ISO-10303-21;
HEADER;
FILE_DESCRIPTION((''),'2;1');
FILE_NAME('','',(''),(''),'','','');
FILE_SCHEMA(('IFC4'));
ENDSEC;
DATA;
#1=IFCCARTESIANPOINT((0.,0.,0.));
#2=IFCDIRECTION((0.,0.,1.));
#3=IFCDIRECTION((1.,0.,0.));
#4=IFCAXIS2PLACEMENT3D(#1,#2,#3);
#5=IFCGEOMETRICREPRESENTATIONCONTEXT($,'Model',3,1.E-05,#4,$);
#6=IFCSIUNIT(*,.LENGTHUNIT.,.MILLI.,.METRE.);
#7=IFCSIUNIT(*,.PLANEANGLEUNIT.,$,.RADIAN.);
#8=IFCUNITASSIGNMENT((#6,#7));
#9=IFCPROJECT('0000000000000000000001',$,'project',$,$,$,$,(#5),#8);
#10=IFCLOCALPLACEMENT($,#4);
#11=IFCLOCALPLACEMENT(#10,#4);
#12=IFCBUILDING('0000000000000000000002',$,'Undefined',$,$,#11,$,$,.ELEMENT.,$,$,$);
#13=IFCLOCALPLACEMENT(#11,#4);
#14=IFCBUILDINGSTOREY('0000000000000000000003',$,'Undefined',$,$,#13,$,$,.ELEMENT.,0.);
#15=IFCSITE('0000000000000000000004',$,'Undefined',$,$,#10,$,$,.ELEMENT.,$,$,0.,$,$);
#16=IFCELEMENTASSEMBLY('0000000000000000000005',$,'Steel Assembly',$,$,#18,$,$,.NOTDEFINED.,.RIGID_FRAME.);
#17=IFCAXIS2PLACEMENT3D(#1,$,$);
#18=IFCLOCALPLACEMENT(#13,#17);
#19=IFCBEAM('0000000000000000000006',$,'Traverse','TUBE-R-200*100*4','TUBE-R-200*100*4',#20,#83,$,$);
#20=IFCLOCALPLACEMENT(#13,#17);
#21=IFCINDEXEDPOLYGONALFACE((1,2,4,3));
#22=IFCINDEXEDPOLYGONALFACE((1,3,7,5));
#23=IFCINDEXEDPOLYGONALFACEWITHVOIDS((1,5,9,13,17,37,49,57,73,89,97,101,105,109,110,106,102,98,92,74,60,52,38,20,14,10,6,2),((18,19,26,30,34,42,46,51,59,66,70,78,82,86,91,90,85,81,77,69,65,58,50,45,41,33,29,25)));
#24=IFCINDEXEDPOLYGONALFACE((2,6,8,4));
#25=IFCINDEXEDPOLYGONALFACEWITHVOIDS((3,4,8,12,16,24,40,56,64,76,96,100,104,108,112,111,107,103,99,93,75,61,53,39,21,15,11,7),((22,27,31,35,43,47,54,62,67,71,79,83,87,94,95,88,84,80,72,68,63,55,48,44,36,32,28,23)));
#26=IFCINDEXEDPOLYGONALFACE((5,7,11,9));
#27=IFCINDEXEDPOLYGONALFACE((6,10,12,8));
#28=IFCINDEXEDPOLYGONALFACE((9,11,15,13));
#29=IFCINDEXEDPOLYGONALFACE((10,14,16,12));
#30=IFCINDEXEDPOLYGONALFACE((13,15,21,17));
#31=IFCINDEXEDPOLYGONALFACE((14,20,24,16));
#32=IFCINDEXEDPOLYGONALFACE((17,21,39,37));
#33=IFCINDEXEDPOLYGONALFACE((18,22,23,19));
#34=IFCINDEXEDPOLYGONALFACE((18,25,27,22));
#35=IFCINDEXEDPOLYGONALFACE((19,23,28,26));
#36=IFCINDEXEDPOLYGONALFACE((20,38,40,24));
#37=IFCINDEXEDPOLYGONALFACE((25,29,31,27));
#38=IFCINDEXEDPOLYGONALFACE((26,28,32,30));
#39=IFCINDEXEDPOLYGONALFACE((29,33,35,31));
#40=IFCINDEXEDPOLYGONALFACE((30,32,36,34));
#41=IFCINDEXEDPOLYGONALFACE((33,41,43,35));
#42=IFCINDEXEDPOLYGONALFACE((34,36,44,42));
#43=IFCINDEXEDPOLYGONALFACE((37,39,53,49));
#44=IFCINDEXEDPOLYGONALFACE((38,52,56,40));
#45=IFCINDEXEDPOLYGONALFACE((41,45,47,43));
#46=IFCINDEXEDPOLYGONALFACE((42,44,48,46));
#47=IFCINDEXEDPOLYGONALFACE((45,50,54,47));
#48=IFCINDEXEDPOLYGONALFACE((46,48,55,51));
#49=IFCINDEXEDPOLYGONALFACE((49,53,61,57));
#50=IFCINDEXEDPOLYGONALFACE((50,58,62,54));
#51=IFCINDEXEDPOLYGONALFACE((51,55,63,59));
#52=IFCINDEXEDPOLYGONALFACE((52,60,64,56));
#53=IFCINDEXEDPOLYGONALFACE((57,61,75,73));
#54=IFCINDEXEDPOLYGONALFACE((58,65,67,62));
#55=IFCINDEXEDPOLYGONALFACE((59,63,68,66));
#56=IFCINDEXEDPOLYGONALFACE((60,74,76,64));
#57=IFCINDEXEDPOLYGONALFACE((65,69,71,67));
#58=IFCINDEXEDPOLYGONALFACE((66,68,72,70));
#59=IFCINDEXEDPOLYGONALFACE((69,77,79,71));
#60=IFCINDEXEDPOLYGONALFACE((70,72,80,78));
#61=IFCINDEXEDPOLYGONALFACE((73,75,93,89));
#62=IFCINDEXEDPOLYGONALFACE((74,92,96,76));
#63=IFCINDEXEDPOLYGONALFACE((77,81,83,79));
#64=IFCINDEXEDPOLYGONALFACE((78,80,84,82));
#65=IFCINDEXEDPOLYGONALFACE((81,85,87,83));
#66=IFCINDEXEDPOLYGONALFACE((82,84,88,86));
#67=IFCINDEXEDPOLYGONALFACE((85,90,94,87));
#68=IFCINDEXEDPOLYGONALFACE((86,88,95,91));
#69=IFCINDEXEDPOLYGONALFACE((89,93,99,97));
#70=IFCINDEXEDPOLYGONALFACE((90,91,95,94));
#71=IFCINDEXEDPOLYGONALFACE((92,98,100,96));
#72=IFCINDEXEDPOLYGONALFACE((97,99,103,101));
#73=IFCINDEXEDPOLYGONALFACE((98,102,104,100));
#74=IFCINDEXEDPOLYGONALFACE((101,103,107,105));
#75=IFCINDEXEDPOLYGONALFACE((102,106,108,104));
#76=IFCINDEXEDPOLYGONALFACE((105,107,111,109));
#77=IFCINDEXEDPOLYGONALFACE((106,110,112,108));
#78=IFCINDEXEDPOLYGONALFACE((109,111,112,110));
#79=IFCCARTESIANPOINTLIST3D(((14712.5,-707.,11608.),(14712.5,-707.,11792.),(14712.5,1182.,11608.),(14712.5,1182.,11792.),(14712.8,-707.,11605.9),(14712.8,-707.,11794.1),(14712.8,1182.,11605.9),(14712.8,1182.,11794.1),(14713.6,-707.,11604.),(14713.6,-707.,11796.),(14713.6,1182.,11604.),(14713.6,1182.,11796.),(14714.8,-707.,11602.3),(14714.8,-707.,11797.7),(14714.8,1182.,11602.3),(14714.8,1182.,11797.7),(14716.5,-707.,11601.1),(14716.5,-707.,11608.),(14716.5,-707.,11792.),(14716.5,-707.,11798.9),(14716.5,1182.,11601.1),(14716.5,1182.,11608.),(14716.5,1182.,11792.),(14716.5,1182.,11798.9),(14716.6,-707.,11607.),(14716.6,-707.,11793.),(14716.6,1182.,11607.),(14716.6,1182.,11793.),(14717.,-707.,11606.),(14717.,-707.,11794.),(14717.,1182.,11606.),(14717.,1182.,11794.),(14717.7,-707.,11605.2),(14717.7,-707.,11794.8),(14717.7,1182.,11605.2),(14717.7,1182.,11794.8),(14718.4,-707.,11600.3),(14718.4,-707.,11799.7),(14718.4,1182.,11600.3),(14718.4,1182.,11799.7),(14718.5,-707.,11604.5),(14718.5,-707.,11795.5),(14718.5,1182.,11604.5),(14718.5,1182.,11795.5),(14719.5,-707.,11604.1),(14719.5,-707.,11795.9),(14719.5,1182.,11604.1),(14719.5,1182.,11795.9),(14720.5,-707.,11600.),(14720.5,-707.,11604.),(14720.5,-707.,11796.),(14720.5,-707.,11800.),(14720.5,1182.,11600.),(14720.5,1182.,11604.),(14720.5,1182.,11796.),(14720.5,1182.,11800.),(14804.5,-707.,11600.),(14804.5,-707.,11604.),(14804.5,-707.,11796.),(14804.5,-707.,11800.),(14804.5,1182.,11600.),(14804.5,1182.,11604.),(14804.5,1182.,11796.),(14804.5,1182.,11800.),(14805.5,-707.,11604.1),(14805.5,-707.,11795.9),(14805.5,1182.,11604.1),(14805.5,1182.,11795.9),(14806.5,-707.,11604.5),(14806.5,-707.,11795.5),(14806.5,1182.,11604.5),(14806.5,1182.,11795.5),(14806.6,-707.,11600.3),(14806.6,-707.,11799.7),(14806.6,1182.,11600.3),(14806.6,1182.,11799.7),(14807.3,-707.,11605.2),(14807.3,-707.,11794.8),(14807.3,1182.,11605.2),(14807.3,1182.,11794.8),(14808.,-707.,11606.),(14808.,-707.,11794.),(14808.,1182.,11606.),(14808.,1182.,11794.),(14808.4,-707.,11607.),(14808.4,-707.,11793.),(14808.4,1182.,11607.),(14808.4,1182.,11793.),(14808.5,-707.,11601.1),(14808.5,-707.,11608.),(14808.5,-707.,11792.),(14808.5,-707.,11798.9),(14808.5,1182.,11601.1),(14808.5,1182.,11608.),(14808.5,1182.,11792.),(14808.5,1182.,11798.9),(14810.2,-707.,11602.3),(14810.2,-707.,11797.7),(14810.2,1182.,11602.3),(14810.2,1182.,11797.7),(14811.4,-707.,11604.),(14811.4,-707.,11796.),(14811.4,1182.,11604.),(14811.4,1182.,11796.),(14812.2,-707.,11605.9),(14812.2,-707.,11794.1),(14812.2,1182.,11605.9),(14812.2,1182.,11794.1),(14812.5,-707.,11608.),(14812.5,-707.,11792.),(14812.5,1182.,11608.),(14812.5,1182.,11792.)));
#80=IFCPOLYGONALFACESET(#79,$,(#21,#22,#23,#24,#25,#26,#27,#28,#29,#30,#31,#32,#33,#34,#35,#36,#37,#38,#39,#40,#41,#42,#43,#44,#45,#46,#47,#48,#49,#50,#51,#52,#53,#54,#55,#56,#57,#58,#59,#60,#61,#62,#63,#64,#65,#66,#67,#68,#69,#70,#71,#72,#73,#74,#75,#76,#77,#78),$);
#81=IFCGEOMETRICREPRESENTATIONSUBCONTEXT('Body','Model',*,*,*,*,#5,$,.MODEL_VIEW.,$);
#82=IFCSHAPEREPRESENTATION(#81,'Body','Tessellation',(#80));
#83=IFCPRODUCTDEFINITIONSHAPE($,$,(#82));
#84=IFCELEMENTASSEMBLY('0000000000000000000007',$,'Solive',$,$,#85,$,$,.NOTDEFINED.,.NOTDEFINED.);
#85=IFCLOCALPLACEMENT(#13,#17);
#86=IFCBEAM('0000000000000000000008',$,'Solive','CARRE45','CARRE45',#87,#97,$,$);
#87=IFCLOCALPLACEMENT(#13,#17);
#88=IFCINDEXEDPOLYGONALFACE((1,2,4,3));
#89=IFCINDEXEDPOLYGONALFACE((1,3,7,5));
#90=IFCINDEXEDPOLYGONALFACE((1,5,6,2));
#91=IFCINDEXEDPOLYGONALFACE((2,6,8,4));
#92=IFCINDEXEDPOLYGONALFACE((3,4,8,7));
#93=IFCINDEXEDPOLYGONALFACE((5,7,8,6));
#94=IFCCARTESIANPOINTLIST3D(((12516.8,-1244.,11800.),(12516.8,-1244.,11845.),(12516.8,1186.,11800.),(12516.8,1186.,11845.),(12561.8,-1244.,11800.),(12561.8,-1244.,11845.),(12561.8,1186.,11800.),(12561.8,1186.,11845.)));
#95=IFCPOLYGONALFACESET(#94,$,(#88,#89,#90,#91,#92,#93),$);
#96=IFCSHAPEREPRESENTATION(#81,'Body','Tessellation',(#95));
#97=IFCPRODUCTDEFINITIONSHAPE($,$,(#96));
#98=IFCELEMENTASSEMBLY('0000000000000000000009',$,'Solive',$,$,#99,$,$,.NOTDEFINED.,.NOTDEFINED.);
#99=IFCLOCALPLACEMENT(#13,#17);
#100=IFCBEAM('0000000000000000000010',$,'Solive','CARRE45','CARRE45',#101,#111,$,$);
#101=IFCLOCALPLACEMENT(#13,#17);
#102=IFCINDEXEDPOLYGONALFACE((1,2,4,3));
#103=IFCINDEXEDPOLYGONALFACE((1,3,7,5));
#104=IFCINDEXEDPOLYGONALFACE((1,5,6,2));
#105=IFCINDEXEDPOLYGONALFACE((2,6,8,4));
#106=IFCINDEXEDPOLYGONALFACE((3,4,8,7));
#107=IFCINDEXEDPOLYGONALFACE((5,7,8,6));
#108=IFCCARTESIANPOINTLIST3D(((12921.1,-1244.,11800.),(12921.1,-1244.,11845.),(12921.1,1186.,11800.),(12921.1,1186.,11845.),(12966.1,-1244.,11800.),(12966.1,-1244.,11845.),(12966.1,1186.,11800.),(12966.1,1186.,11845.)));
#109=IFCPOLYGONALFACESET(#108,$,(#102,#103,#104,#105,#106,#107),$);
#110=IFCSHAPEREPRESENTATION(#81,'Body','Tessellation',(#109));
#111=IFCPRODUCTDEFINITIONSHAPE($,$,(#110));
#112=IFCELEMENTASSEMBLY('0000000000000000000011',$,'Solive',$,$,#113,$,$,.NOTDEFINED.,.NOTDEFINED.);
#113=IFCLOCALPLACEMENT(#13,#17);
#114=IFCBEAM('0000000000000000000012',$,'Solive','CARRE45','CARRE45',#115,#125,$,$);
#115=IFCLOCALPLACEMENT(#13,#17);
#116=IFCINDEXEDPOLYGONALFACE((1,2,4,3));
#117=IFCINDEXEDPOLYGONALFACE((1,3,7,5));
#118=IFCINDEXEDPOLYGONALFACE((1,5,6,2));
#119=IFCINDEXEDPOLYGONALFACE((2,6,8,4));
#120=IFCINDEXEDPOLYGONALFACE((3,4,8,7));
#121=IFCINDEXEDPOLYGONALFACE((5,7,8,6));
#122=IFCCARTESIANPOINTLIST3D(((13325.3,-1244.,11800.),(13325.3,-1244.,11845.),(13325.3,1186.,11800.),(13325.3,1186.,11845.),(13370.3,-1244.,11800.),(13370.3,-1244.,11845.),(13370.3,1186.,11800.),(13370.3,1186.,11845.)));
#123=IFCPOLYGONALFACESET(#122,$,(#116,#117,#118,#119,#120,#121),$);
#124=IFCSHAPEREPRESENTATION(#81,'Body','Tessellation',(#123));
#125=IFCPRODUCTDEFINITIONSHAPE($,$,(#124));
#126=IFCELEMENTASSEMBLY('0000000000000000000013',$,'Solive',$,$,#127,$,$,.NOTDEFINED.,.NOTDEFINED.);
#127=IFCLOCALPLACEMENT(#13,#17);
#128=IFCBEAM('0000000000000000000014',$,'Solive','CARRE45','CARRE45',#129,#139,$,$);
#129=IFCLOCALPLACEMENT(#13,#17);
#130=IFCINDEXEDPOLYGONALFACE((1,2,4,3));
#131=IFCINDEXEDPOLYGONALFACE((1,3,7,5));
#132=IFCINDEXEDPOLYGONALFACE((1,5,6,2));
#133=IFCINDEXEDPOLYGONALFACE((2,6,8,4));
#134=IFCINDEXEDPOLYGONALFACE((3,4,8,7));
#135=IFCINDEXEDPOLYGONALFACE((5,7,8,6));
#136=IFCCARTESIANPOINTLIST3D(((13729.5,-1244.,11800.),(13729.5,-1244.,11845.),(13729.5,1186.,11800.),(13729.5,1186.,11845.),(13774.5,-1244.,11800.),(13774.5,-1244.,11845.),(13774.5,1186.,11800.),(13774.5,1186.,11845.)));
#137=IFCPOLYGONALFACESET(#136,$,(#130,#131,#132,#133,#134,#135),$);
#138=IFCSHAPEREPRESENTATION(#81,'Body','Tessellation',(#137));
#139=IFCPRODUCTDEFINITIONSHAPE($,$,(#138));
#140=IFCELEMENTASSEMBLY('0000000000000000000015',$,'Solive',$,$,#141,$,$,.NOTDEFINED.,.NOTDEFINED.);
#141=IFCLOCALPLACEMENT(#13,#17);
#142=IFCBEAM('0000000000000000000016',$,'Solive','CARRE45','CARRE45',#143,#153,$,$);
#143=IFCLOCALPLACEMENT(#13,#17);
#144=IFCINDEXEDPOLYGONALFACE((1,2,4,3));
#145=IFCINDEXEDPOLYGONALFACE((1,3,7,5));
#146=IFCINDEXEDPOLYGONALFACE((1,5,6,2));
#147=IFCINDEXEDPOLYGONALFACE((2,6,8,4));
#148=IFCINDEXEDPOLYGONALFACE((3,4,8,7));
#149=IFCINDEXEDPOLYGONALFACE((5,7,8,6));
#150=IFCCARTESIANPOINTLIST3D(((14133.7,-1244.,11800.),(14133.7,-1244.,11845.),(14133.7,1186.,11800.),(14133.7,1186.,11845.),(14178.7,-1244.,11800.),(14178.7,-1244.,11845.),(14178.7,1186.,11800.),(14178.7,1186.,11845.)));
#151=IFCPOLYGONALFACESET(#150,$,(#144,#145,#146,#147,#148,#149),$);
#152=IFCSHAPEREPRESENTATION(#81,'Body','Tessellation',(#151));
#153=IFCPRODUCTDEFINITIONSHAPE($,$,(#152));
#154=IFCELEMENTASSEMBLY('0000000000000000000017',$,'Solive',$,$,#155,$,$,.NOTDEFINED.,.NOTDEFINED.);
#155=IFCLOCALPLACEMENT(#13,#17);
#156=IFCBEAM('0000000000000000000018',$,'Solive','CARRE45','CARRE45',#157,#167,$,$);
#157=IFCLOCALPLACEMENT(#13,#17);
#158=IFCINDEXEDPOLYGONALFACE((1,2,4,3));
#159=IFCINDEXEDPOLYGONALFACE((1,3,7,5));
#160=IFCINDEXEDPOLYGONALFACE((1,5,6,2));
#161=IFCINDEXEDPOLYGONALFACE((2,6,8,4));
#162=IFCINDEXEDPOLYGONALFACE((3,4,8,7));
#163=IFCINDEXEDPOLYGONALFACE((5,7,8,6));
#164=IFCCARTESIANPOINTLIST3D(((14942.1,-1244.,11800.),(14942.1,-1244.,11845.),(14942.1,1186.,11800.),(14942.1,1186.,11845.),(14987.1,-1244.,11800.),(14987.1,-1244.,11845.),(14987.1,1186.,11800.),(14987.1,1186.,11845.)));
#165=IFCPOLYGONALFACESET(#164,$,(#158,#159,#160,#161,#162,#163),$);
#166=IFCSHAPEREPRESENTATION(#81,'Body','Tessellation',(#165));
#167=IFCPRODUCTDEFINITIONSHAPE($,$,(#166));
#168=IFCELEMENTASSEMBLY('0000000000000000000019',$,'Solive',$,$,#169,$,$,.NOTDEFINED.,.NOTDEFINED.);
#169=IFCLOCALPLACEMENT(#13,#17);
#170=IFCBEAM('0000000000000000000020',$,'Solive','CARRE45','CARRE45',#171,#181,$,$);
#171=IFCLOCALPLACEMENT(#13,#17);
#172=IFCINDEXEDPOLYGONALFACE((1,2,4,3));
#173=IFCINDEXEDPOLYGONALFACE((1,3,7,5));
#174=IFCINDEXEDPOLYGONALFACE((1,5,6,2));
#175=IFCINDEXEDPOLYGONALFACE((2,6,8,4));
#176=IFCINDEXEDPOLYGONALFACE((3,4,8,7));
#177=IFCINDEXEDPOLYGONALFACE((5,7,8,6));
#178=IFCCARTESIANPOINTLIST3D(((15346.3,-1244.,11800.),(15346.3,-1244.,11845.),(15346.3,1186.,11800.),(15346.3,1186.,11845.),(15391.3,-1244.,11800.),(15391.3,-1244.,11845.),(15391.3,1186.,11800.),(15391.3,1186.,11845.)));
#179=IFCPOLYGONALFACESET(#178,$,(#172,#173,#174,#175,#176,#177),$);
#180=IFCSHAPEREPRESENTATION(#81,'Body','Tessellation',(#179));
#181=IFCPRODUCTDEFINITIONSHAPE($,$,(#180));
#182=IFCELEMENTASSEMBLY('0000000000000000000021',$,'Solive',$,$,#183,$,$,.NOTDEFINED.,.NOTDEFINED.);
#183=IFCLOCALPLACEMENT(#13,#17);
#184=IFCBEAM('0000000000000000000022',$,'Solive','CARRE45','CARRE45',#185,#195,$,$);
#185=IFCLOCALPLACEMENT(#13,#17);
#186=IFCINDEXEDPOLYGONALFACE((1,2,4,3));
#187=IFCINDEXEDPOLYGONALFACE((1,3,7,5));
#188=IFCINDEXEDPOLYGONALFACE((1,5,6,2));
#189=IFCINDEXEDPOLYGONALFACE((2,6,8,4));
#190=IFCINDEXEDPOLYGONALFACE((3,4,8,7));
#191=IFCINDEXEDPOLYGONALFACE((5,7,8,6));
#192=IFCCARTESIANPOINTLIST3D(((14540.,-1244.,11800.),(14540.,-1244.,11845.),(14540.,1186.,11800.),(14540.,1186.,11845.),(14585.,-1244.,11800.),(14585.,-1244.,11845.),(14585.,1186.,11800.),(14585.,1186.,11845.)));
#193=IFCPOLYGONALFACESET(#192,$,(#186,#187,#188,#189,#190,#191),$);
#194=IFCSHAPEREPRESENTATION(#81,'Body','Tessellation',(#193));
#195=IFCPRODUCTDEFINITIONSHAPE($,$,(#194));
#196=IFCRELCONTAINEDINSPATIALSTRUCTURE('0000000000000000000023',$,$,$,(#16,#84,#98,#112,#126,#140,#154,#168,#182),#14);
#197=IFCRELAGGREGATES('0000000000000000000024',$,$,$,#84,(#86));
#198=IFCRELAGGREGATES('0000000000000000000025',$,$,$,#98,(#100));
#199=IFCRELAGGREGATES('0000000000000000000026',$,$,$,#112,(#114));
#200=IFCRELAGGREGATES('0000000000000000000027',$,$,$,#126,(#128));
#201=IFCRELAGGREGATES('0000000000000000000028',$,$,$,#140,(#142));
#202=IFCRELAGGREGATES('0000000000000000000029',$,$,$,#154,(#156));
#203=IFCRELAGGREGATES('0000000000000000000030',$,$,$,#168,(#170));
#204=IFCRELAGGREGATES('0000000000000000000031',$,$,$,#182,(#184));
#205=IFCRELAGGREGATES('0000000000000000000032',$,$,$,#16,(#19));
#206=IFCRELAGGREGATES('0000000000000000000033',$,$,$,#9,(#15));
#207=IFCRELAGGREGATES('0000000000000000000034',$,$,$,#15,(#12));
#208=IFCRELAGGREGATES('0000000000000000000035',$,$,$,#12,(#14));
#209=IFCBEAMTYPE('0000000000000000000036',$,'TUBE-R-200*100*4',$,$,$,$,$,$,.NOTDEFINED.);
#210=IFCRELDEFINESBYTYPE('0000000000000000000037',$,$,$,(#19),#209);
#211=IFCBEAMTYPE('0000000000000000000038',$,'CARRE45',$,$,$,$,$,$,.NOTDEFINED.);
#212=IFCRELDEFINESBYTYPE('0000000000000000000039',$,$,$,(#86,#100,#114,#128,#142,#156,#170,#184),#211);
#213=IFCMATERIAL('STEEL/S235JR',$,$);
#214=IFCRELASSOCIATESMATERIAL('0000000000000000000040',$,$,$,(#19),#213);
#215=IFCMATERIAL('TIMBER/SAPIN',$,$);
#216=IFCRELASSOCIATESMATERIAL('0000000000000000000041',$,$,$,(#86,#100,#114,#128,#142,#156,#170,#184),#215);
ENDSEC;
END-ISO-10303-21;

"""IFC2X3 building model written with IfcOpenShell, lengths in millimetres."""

from ifc_helpers import new_model, si_unit, frame, origin_with_axes, origin_2d_with_axis, place, context, subcontext, project, spatial, rectangle, hollow_rectangle, extrude, material, type_object, element, aggregate, save


model = new_model("IFC2X3")

# Units and contexts
model_context = context("Model", 3, precision=1e-05, world=origin_with_axes())
body_context = subcontext(model_context, "Body", "Model", "MODEL_VIEW")
ifc_project = project(units=[si_unit("LENGTHUNIT", "METRE", prefix="MILLI"), si_unit("PLANEANGLEUNIT", "RADIAN")], contexts=[model_context])

# Site, building, storey
site_placement = place(None, origin_with_axes())
site = spatial("IfcSite", under=ifc_project, at=site_placement, Name="Undefined", CompositionType="ELEMENT", RefElevation=0.0)
building_placement = place(site_placement, origin_with_axes())
building = spatial("IfcBuilding", under=site, at=building_placement, Name="Undefined", CompositionType="ELEMENT")
storey_placement = place(building_placement, origin_with_axes())
storey = spatial("IfcBuildingStorey", under=building, at=storey_placement, Name="Undefined", CompositionType="ELEMENT", Elevation=0.0)

# Element assemblies, beams
assembly_1_placement = place(storey_placement, origin_with_axes())
assembly_1 = element("IfcElementAssembly", 1, at=assembly_1_placement, inside=storey, Name="Steel Assembly", AssemblyPlace="NOTDEFINED", PredefinedType="RIGID_FRAME")
ifc_material_1 = material(Name="STEEL/S235JR")
beam_type_1 = type_object("IfcBeamType", Name="TUBE-R-200*100*4", PredefinedType="NOTDEFINED")
beam_1_placement = place(assembly_1_placement, frame((14762.5, 1190.0, 11700.0), z_axis=(0.0, 0.0, 1.0), x_axis=(0.0, -1.0, 0.0)))
beam_1 = element("IfcBeam", 2, at=beam_1_placement, type_object=beam_type_1, material=ifc_material_1, Name="Traverse", Description="TUBE-R-200*100*4", ObjectType="TUBE-R-200*100*4", context=body_context, shape_type="SweptSolid", body=[
    extrude(hollow_rectangle(XDim=100.0, YDim=200.0, WallThickness=4.0, InnerFilletRadius=4.0, OuterFilletRadius=8.0, at=origin_2d_with_axis()), frame((1897.0, 0.0, 0.0), z_axis=(-1.0, 0.0, 0.0), x_axis=(0.0, -1.0, 0.0)), (0.0, 0.0, 1.0), 1889.0),
])
assembly_2_placement = place(storey_placement, origin_with_axes())
assembly_2 = element("IfcElementAssembly", 3, at=assembly_2_placement, inside=storey, Name="Solive", AssemblyPlace="NOTDEFINED", PredefinedType="NOTDEFINED")
ifc_material_2 = material(Name="TIMBER/SAPIN")
beam_type_2 = type_object("IfcBeamType", Name="CARRE45", PredefinedType="NOTDEFINED")
beam_2_placement = place(assembly_2_placement, frame((12539.3, 1186.0, 11822.5), z_axis=(0.0, 0.0, -1.0), x_axis=(0.0, -1.0, 0.0)))
beam_2 = element("IfcBeam", 4, at=beam_2_placement, type_object=beam_type_2, material=ifc_material_2, Name="Solive", Description="CARRE45", ObjectType="CARRE45", context=body_context, shape_type="SweptSolid", body=[
    extrude(rectangle(XDim=45.0, YDim=45.0, at=origin_2d_with_axis()), frame((2430.0, 0.0, 0.0), z_axis=(-1.0, 0.0, 0.0), x_axis=(0.0, -1.0, 0.0)), (0.0, 0.0, 1.0), 2430.0),
])
aggregate(assembly_2, [beam_2])
assembly_3_placement = place(storey_placement, origin_with_axes())
assembly_3 = element("IfcElementAssembly", 5, at=assembly_3_placement, inside=storey, Name="Solive", AssemblyPlace="NOTDEFINED", PredefinedType="NOTDEFINED")
beam_3_placement = place(assembly_3_placement, frame((12943.6, 1186.0, 11822.5), z_axis=(0.0, 0.0, -1.0), x_axis=(0.0, -1.0, 0.0)))
beam_3 = element("IfcBeam", 6, at=beam_3_placement, type_object=beam_type_2, material=ifc_material_2, Name="Solive", Description="CARRE45", ObjectType="CARRE45", context=body_context, shape_type="SweptSolid", body=[
    extrude(rectangle(XDim=45.0, YDim=45.0, at=origin_2d_with_axis()), frame((2430.0, 0.0, 0.0), z_axis=(-1.0, 0.0, 0.0), x_axis=(0.0, -1.0, 0.0)), (0.0, 0.0, 1.0), 2430.0),
])
aggregate(assembly_3, [beam_3])
assembly_4_placement = place(storey_placement, origin_with_axes())
assembly_4 = element("IfcElementAssembly", 7, at=assembly_4_placement, inside=storey, Name="Solive", AssemblyPlace="NOTDEFINED", PredefinedType="NOTDEFINED")
beam_4_placement = place(assembly_4_placement, frame((13347.8, 1186.0, 11822.5), z_axis=(0.0, 0.0, -1.0), x_axis=(0.0, -1.0, 0.0)))
beam_4 = element("IfcBeam", 8, at=beam_4_placement, type_object=beam_type_2, material=ifc_material_2, Name="Solive", Description="CARRE45", ObjectType="CARRE45", context=body_context, shape_type="SweptSolid", body=[
    extrude(rectangle(XDim=45.0, YDim=45.0, at=origin_2d_with_axis()), frame((2430.0, 0.0, 0.0), z_axis=(-1.0, 0.0, 0.0), x_axis=(0.0, -1.0, 0.0)), (0.0, 0.0, 1.0), 2430.0),
])
aggregate(assembly_4, [beam_4])
assembly_5_placement = place(storey_placement, origin_with_axes())
assembly_5 = element("IfcElementAssembly", 9, at=assembly_5_placement, inside=storey, Name="Solive", AssemblyPlace="NOTDEFINED", PredefinedType="NOTDEFINED")
beam_5_placement = place(assembly_5_placement, frame((13752.0, 1186.0, 11822.5), z_axis=(0.0, 0.0, -1.0), x_axis=(0.0, -1.0, 0.0)))
beam_5 = element("IfcBeam", 10, at=beam_5_placement, type_object=beam_type_2, material=ifc_material_2, Name="Solive", Description="CARRE45", ObjectType="CARRE45", context=body_context, shape_type="SweptSolid", body=[
    extrude(rectangle(XDim=45.0, YDim=45.0, at=origin_2d_with_axis()), frame((2430.0, 0.0, 0.0), z_axis=(-1.0, 0.0, 0.0), x_axis=(0.0, -1.0, 0.0)), (0.0, 0.0, 1.0), 2430.0),
])
aggregate(assembly_5, [beam_5])
assembly_6_placement = place(storey_placement, origin_with_axes())
assembly_6 = element("IfcElementAssembly", 11, at=assembly_6_placement, inside=storey, Name="Solive", AssemblyPlace="NOTDEFINED", PredefinedType="NOTDEFINED")
beam_6_placement = place(assembly_6_placement, frame((14156.2, 1186.0, 11822.5), z_axis=(0.0, 0.0, -1.0), x_axis=(0.0, -1.0, 0.0)))
beam_6 = element("IfcBeam", 12, at=beam_6_placement, type_object=beam_type_2, material=ifc_material_2, Name="Solive", Description="CARRE45", ObjectType="CARRE45", context=body_context, shape_type="SweptSolid", body=[
    extrude(rectangle(XDim=45.0, YDim=45.0, at=origin_2d_with_axis()), frame((2430.0, 0.0, 0.0), z_axis=(-1.0, 0.0, 0.0), x_axis=(0.0, -1.0, 0.0)), (0.0, 0.0, 1.0), 2430.0),
])
aggregate(assembly_6, [beam_6])
assembly_7_placement = place(storey_placement, origin_with_axes())
assembly_7 = element("IfcElementAssembly", 13, at=assembly_7_placement, inside=storey, Name="Solive", AssemblyPlace="NOTDEFINED", PredefinedType="NOTDEFINED")
beam_7_placement = place(assembly_7_placement, frame((14964.6, 1186.0, 11822.5), z_axis=(0.0, 0.0, -1.0), x_axis=(0.0, -1.0, 0.0)))
beam_7 = element("IfcBeam", 14, at=beam_7_placement, type_object=beam_type_2, material=ifc_material_2, Name="Solive", Description="CARRE45", ObjectType="CARRE45", context=body_context, shape_type="SweptSolid", body=[
    extrude(rectangle(XDim=45.0, YDim=45.0, at=origin_2d_with_axis()), frame((2430.0, 0.0, 0.0), z_axis=(-1.0, 0.0, 0.0), x_axis=(0.0, -1.0, 0.0)), (0.0, 0.0, 1.0), 2430.0),
])
aggregate(assembly_7, [beam_7])
assembly_8_placement = place(storey_placement, origin_with_axes())
assembly_8 = element("IfcElementAssembly", 15, at=assembly_8_placement, inside=storey, Name="Solive", AssemblyPlace="NOTDEFINED", PredefinedType="NOTDEFINED")
beam_8_placement = place(assembly_8_placement, frame((15368.8, 1186.0, 11822.5), z_axis=(0.0, 0.0, -1.0), x_axis=(0.0, -1.0, 0.0)))
beam_8 = element("IfcBeam", 16, at=beam_8_placement, type_object=beam_type_2, material=ifc_material_2, Name="Solive", Description="CARRE45", ObjectType="CARRE45", context=body_context, shape_type="SweptSolid", body=[
    extrude(rectangle(XDim=45.0, YDim=45.0, at=origin_2d_with_axis()), frame((2430.0, 0.0, 0.0), z_axis=(-1.0, 0.0, 0.0), x_axis=(0.0, -1.0, 0.0)), (0.0, 0.0, 1.0), 2430.0),
])
aggregate(assembly_8, [beam_8])
assembly_9_placement = place(storey_placement, origin_with_axes())
assembly_9 = element("IfcElementAssembly", 17, at=assembly_9_placement, inside=storey, Name="Solive", AssemblyPlace="NOTDEFINED", PredefinedType="NOTDEFINED")
beam_9_placement = place(assembly_9_placement, frame((14562.5, 1186.0, 11822.5), z_axis=(0.0, 0.0, -1.0), x_axis=(0.0, -1.0, 0.0)))
beam_9 = element("IfcBeam", 18, at=beam_9_placement, type_object=beam_type_2, material=ifc_material_2, Name="Solive", Description="CARRE45", ObjectType="CARRE45", context=body_context, shape_type="SweptSolid", body=[
    extrude(rectangle(XDim=45.0, YDim=45.0, at=origin_2d_with_axis()), frame((2430.0, 0.0, 0.0), z_axis=(-1.0, 0.0, 0.0), x_axis=(0.0, -1.0, 0.0)), (0.0, 0.0, 1.0), 2430.0),
])
aggregate(assembly_9, [beam_9])

aggregate(assembly_1, [beam_1])

save(model, "model.ifc")
